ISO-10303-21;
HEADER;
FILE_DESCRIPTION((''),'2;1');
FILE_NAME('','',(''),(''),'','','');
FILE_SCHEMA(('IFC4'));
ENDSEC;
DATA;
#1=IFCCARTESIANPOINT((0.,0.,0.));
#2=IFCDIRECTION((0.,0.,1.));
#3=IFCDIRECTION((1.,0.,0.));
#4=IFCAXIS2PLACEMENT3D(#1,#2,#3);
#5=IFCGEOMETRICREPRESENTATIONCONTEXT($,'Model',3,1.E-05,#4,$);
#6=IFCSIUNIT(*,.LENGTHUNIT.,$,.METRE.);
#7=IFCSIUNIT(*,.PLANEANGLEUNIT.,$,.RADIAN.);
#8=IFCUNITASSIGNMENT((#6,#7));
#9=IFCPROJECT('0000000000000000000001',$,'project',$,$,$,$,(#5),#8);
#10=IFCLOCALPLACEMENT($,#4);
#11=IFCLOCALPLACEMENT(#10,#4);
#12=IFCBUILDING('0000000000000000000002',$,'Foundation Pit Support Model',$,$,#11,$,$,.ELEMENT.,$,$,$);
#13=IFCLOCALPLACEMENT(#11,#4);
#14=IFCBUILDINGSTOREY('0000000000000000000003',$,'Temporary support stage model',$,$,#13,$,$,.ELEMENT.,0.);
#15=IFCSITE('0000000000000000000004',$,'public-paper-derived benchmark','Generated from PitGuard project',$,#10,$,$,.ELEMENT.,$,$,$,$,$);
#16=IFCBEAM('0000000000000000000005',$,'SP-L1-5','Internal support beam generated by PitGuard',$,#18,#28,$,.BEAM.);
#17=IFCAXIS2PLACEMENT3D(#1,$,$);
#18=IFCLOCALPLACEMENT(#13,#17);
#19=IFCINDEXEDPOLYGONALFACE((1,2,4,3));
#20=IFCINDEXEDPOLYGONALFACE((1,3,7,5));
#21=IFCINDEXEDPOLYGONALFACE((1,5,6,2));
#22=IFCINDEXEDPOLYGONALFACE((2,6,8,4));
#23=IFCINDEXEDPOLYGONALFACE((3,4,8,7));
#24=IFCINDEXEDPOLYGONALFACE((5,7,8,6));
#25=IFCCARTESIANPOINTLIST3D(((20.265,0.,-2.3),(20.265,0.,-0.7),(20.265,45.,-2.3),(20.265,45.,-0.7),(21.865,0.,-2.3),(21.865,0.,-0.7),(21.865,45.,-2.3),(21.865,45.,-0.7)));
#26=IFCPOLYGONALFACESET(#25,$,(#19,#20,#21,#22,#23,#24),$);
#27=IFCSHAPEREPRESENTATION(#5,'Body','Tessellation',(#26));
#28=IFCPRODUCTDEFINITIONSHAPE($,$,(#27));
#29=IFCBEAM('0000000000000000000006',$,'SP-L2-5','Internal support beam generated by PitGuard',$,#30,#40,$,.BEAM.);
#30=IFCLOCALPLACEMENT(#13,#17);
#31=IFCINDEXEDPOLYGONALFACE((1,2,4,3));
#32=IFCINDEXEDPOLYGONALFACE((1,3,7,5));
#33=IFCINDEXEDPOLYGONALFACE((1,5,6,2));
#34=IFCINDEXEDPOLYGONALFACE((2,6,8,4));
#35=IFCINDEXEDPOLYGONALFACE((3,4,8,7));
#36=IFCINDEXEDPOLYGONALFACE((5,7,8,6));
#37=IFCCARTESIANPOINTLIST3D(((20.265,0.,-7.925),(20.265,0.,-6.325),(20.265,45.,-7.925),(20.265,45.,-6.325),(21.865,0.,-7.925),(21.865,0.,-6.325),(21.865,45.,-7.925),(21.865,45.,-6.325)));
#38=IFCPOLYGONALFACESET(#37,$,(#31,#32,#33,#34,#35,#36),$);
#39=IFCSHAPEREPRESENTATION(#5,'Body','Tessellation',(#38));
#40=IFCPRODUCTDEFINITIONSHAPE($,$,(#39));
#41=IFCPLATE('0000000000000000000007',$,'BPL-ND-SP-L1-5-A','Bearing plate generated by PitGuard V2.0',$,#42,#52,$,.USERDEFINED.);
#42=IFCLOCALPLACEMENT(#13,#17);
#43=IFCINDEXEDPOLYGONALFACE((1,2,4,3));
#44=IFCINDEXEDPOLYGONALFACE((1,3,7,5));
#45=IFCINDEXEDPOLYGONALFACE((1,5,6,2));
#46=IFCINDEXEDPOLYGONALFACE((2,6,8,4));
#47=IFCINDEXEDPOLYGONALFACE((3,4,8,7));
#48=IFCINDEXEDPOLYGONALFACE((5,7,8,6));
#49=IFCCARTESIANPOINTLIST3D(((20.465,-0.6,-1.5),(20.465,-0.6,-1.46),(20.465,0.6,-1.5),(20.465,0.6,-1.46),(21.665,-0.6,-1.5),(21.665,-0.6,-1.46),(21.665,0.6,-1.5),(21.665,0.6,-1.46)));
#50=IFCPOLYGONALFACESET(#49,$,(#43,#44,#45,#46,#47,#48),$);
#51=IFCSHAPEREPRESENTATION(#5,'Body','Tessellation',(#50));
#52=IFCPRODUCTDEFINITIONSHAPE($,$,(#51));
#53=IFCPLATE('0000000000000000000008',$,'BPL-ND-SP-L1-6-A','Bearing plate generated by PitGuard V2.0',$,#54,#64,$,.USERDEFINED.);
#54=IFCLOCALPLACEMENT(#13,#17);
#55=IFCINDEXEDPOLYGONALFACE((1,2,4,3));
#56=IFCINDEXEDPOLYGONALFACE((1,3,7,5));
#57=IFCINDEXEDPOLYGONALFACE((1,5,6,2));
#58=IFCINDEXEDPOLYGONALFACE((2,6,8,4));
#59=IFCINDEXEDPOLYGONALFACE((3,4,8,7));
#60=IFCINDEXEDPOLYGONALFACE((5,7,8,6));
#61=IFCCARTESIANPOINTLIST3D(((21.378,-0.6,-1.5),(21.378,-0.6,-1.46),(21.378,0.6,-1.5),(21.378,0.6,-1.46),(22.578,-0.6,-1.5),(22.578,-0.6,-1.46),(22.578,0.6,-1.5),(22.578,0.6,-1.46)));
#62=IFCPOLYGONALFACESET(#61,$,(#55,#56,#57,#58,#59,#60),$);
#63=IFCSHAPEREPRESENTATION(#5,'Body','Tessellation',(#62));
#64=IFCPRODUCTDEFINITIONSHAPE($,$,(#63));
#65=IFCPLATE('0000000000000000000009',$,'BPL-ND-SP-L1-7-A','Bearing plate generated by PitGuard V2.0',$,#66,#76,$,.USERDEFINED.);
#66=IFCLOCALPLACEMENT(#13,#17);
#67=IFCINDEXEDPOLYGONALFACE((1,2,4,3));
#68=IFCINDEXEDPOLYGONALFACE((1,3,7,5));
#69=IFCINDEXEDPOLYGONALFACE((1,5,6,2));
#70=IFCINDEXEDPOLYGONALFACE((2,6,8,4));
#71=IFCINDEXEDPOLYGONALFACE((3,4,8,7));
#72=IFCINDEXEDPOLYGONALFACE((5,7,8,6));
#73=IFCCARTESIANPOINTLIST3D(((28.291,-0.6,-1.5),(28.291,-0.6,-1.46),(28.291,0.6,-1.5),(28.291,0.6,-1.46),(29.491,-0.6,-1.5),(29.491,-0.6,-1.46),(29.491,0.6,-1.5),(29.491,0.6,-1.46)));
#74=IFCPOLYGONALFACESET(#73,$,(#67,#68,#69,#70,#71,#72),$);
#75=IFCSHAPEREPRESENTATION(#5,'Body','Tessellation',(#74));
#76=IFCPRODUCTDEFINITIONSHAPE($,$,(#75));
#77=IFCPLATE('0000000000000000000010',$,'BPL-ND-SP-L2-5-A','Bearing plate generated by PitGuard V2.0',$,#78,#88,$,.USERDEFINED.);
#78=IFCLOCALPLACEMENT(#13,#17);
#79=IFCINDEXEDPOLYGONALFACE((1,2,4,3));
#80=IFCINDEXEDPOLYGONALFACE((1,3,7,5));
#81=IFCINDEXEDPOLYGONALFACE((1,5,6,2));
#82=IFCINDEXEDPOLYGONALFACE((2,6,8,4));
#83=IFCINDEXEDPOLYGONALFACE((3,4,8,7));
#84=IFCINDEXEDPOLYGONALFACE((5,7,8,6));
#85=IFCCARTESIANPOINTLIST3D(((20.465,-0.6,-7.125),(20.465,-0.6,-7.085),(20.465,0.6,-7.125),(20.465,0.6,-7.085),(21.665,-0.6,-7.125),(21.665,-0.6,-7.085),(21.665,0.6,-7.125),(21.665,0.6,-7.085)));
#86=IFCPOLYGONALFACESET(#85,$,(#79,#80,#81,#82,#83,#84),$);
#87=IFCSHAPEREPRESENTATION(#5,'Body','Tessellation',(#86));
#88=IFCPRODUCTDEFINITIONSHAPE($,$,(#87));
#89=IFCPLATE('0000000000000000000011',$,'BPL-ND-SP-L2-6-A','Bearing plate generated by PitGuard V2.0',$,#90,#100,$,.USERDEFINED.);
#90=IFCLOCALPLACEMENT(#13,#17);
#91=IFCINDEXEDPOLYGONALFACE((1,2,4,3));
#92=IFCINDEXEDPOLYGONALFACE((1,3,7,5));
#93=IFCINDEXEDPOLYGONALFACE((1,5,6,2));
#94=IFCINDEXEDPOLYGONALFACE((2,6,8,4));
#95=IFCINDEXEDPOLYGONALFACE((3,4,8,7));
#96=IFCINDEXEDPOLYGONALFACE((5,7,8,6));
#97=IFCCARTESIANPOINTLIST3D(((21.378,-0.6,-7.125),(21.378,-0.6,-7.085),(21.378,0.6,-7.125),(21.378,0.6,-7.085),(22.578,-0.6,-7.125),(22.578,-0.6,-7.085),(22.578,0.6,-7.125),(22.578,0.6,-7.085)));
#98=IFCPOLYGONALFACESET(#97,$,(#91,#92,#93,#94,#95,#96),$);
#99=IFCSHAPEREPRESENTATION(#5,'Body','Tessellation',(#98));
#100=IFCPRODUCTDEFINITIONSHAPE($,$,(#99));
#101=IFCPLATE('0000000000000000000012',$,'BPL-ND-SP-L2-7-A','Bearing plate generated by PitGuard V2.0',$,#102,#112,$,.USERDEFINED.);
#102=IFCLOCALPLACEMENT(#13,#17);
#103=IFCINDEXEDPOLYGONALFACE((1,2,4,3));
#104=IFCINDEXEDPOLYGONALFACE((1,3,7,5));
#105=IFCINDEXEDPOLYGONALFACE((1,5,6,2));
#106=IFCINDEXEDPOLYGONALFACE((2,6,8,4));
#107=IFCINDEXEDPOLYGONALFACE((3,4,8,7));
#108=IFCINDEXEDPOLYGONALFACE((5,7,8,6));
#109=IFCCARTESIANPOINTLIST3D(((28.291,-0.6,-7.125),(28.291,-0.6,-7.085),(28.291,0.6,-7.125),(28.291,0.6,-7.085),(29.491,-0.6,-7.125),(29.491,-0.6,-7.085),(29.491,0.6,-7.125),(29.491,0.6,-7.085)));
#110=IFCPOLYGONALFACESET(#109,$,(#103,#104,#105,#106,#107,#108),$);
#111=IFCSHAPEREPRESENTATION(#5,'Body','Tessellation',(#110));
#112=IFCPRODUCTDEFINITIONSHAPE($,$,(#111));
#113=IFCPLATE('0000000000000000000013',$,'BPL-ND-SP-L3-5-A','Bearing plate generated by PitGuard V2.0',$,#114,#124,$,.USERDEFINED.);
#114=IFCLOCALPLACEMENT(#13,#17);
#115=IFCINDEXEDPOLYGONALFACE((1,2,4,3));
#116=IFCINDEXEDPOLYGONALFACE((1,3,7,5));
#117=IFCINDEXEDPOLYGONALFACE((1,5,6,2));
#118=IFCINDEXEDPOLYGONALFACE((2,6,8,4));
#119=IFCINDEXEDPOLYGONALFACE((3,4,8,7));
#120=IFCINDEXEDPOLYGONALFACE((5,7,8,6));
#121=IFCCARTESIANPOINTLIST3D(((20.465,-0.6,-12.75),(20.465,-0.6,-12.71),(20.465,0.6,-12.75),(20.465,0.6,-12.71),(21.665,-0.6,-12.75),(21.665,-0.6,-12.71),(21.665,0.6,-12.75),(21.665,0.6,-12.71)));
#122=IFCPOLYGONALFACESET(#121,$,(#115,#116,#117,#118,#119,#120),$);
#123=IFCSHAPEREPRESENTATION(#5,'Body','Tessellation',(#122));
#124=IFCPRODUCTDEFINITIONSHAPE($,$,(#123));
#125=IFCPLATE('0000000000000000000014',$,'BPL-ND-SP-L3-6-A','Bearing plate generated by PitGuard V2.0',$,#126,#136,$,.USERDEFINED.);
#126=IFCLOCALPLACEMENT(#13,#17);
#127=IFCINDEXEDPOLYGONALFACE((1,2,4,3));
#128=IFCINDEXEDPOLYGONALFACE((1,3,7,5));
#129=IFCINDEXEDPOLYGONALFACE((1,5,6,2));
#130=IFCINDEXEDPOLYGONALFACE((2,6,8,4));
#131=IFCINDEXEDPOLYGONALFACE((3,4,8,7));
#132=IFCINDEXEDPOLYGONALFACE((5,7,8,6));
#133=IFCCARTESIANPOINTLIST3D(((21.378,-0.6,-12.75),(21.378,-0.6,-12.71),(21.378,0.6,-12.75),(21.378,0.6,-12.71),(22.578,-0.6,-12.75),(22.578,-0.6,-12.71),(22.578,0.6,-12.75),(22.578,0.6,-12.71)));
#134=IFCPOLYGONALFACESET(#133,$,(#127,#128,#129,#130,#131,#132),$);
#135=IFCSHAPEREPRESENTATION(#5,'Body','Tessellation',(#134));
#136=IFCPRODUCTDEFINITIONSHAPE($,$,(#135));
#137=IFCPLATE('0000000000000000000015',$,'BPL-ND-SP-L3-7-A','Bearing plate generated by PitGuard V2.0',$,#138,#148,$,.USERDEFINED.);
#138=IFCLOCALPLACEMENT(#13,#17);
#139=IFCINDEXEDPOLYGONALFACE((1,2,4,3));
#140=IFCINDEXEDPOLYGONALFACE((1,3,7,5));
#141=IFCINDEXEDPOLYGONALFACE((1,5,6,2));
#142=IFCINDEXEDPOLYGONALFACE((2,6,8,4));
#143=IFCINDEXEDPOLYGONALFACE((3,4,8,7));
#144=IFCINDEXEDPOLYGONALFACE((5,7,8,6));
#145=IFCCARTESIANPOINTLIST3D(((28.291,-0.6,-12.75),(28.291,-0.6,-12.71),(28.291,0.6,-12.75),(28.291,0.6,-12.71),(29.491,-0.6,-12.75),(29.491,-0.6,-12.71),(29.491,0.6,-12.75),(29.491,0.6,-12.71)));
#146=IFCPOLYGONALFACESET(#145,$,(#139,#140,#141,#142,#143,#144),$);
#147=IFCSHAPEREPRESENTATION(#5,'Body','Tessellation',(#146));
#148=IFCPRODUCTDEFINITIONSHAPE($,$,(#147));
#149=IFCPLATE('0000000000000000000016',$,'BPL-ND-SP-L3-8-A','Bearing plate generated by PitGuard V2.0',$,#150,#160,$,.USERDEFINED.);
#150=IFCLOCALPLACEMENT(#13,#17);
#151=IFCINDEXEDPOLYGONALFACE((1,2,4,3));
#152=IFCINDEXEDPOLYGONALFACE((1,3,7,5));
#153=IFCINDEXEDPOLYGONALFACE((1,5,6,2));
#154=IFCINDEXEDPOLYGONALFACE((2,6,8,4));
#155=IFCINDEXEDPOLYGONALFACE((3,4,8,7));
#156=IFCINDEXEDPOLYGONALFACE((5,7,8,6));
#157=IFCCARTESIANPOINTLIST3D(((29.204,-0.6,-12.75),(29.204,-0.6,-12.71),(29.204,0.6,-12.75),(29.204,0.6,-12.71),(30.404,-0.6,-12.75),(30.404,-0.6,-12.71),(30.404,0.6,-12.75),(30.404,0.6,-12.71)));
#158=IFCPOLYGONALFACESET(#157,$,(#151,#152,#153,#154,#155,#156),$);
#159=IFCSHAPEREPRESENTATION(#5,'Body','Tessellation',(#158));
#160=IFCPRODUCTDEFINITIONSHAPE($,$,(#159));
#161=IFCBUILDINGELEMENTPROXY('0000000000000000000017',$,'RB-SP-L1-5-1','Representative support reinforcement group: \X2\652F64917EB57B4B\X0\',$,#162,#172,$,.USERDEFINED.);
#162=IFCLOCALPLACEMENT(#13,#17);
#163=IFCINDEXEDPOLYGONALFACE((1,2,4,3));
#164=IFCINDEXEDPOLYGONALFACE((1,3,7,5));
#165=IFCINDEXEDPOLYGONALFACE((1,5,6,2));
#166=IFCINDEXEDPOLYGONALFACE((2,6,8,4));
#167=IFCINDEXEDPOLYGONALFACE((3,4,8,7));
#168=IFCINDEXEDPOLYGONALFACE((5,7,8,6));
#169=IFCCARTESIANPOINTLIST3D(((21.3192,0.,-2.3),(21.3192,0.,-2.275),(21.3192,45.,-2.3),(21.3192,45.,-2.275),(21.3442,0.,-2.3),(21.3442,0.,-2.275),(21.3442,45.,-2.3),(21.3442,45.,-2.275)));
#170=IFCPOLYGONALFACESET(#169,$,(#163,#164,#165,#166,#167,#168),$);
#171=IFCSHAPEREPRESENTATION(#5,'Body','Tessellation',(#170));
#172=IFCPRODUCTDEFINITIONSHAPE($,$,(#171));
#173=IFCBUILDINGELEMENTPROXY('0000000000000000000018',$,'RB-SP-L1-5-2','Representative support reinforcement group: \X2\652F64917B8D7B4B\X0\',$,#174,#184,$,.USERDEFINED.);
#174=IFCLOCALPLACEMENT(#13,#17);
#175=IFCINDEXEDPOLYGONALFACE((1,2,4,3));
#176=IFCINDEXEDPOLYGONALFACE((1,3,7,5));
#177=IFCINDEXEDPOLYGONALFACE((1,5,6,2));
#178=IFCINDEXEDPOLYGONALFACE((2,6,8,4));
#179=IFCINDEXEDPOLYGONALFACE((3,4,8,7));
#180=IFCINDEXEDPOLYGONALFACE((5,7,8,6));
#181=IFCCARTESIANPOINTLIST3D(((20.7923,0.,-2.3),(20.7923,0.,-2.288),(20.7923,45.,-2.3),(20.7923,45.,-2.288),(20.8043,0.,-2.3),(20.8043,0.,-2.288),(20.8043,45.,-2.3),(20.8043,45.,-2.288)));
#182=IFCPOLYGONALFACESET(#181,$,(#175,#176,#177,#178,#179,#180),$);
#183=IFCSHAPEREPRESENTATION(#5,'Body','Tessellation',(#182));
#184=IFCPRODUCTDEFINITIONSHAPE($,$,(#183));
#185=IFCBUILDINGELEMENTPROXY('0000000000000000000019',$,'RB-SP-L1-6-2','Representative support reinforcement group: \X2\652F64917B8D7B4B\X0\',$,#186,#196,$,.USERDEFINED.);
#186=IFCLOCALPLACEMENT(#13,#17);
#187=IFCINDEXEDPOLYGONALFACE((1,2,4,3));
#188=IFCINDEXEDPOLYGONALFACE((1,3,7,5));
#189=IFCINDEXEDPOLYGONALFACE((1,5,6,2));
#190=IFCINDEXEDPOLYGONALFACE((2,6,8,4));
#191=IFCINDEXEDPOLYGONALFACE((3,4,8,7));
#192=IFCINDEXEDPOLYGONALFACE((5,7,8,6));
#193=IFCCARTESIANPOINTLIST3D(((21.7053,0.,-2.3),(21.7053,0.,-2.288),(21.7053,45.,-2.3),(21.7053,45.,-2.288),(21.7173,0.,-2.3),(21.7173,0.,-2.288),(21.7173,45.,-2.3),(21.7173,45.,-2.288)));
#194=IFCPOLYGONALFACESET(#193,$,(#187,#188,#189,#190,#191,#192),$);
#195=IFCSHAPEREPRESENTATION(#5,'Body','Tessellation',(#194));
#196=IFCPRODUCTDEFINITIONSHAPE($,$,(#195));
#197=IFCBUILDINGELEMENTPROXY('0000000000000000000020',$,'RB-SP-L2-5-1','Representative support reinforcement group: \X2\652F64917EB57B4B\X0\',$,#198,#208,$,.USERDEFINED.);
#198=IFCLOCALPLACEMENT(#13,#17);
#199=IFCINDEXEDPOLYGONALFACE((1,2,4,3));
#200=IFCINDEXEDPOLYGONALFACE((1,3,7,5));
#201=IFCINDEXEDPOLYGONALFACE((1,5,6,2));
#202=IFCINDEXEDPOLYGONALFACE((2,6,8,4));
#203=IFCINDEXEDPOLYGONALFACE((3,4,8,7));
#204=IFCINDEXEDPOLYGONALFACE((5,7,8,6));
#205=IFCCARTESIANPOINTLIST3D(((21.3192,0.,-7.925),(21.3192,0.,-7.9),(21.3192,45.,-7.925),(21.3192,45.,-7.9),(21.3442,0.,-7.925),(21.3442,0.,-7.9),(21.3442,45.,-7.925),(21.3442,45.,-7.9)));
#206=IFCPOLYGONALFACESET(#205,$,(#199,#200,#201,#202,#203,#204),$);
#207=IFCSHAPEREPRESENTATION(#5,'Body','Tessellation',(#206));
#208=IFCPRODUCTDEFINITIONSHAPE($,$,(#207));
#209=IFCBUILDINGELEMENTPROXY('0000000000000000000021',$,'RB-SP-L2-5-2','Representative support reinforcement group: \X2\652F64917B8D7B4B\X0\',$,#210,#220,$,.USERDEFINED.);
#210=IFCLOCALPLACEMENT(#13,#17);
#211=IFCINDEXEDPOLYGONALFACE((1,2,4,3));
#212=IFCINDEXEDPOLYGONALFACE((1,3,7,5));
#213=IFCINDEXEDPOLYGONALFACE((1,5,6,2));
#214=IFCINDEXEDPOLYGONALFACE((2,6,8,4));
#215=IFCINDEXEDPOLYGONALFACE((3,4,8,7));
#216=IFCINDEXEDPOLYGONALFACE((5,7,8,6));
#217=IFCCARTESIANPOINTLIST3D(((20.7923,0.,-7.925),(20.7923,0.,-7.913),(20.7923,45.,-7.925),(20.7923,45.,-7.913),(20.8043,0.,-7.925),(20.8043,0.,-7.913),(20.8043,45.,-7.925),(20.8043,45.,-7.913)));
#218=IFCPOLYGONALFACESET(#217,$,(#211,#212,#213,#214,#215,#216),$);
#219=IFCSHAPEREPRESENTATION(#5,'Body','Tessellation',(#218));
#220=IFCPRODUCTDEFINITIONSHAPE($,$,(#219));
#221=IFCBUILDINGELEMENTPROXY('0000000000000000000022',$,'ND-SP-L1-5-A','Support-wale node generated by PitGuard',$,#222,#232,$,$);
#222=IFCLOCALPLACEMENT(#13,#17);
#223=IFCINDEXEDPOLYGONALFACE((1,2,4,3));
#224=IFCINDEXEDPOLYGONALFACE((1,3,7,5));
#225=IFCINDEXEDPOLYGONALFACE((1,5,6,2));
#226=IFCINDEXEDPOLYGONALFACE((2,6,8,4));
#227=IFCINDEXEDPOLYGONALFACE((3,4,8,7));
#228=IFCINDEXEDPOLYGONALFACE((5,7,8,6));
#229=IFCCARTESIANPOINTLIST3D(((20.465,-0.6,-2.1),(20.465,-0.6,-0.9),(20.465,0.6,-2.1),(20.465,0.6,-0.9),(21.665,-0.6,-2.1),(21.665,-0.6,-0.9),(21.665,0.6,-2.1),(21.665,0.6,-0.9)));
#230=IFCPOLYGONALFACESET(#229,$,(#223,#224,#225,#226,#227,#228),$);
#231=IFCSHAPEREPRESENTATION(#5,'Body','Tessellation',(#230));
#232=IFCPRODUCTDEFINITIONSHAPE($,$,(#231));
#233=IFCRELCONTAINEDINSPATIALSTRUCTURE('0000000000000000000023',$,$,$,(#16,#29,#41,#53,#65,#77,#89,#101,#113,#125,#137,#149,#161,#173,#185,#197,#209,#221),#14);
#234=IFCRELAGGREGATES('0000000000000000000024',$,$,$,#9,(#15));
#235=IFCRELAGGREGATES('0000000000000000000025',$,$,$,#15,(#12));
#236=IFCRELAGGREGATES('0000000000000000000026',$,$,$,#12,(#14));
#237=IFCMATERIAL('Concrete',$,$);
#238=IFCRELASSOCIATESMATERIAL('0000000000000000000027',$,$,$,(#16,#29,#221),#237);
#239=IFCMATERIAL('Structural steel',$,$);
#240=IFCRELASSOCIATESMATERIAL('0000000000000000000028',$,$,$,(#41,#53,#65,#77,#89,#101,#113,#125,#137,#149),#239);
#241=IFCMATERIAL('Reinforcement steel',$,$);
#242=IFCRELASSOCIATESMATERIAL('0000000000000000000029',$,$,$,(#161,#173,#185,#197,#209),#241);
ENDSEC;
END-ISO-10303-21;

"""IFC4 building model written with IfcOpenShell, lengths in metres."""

from ifc_helpers import new_model, si_unit, frame, origin_with_axes, origin_2d, place, context, project, spatial, rectangle, extrude, material, element, save


model = new_model("IFC4")

# Units and contexts
model_context = context("Model", 3, precision=1e-05, world=origin_with_axes())
ifc_project = project(units=[si_unit("LENGTHUNIT", "METRE"), si_unit("PLANEANGLEUNIT", "RADIAN")], contexts=[model_context])

# Site, building, storey
site_placement = place(None, origin_with_axes())
site = spatial("IfcSite", under=ifc_project, at=site_placement, Name="public-paper-derived benchmark", Description="Generated from PitGuard project", CompositionType="ELEMENT")
building_placement = place(site_placement, origin_with_axes())
building = spatial("IfcBuilding", under=site, at=building_placement, Name="Foundation Pit Support Model", CompositionType="ELEMENT")
storey_placement = place(building_placement, origin_with_axes())
storey = spatial("IfcBuildingStorey", under=building, at=storey_placement, Name="Temporary support stage model", CompositionType="ELEMENT", Elevation=0.0)

# Beams
ifc_material_1 = material(Name="Concrete")
for number, where, z_axis, x_axis, name in (
    (1, (21.065, 22.5, -2.3), (0.0, 0.0, 1.0), (0.0, 1.0, 0.0), "SP-L1-5"),
    (2, (21.065, 22.5, -7.925), (0.0, 0.0, 1.0), (0.0, 1.0, 0.0), "SP-L2-5"),
):
    element("IfcBeam", number, at=place(storey_placement, frame(where, z_axis=z_axis, x_axis=x_axis)), inside=storey, material=ifc_material_1, Name=name, Description="Internal support beam generated by PitGuard", PredefinedType="BEAM", context=model_context, shape_type="SweptSolid", body=[
        extrude(rectangle(XDim=45.0, YDim=1.6, at=origin_2d()), origin_with_axes(), (0.0, 0.0, 1.0), 1.6),
    ])

# Plates
ifc_material_2 = material(Name="Structural steel")
for number, where, z_axis, x_axis, name in (
    (3, (21.065, 0.0, -1.5), (0.0, 0.0, 1.0), (1.0, 0.0, 0.0), "BPL-ND-SP-L1-5-A"),
    (4, (21.978, 0.0, -1.5), (0.0, 0.0, 1.0), (1.0, 0.0, 0.0), "BPL-ND-SP-L1-6-A"),
    (5, (28.891, 0.0, -1.5), (0.0, 0.0, 1.0), (1.0, 0.0, 0.0), "BPL-ND-SP-L1-7-A"),
    (6, (21.065, 0.0, -7.125), (0.0, 0.0, 1.0), (1.0, 0.0, 0.0), "BPL-ND-SP-L2-5-A"),
    (7, (21.978, 0.0, -7.125), (0.0, 0.0, 1.0), (1.0, 0.0, 0.0), "BPL-ND-SP-L2-6-A"),
    (8, (28.891, 0.0, -7.125), (0.0, 0.0, 1.0), (1.0, 0.0, 0.0), "BPL-ND-SP-L2-7-A"),
    (9, (21.065, 0.0, -12.75), (0.0, 0.0, 1.0), (1.0, 0.0, 0.0), "BPL-ND-SP-L3-5-A"),
    (10, (21.978, 0.0, -12.75), (0.0, 0.0, 1.0), (1.0, 0.0, 0.0), "BPL-ND-SP-L3-6-A"),
    (11, (28.891, 0.0, -12.75), (0.0, 0.0, 1.0), (1.0, 0.0, 0.0), "BPL-ND-SP-L3-7-A"),
    (12, (29.804, 0.0, -12.75), (0.0, 0.0, 1.0), (1.0, 0.0, 0.0), "BPL-ND-SP-L3-8-A"),
):
    element("IfcPlate", number, at=place(storey_placement, frame(where, z_axis=z_axis, x_axis=x_axis)), inside=storey, material=ifc_material_2, Name=name, Description="Bearing plate generated by PitGuard V2.0", PredefinedType="USERDEFINED", context=model_context, shape_type="SweptSolid", body=[
        extrude(rectangle(XDim=1.2, YDim=1.2, at=origin_2d()), origin_with_axes(), (0.0, 0.0, 1.0), 0.04),
    ])

# Building element proxies
ifc_material_3 = material(Name="Reinforcement steel")
proxy_1_placement = place(storey_placement, frame((21.3317, 22.5, -2.3), z_axis=(0.0, 0.0, 1.0), x_axis=(0.0, 1.0, 0.0)))
element("IfcBuildingElementProxy", 13, at=proxy_1_placement, inside=storey, material=ifc_material_3, Name="RB-SP-L1-5-1", Description="Representative support reinforcement group: 支撑纵筋", PredefinedType="USERDEFINED", context=model_context, shape_type="SweptSolid", body=[
    extrude(rectangle(XDim=45.0, YDim=0.025, at=origin_2d()), origin_with_axes(), (0.0, 0.0, 1.0), 0.025),
])
for number, where, z_axis, x_axis, name in (
    (14, (20.7983, 22.5, -2.3), (0.0, 0.0, 1.0), (0.0, 1.0, 0.0), "RB-SP-L1-5-2"),
    (15, (21.7113, 22.5, -2.3), (0.0, 0.0, 1.0), (0.0, 1.0, 0.0), "RB-SP-L1-6-2"),
):
    element("IfcBuildingElementProxy", number, at=place(storey_placement, frame(where, z_axis=z_axis, x_axis=x_axis)), inside=storey, material=ifc_material_3, Name=name, Description="Representative support reinforcement group: 支撑箍筋", PredefinedType="USERDEFINED", context=model_context, shape_type="SweptSolid", body=[
        extrude(rectangle(XDim=45.0, YDim=0.012, at=origin_2d()), origin_with_axes(), (0.0, 0.0, 1.0), 0.012),
    ])
proxy_2_placement = place(storey_placement, frame((21.3317, 22.5, -7.925), z_axis=(0.0, 0.0, 1.0), x_axis=(0.0, 1.0, 0.0)))
element("IfcBuildingElementProxy", 16, at=proxy_2_placement, inside=storey, material=ifc_material_3, Name="RB-SP-L2-5-1", Description="Representative support reinforcement group: 支撑纵筋", PredefinedType="USERDEFINED", context=model_context, shape_type="SweptSolid", body=[
    extrude(rectangle(XDim=45.0, YDim=0.025, at=origin_2d()), origin_with_axes(), (0.0, 0.0, 1.0), 0.025),
])
proxy_3_placement = place(storey_placement, frame((20.7983, 22.5, -7.925), z_axis=(0.0, 0.0, 1.0), x_axis=(0.0, 1.0, 0.0)))
element("IfcBuildingElementProxy", 17, at=proxy_3_placement, inside=storey, material=ifc_material_3, Name="RB-SP-L2-5-2", Description="Representative support reinforcement group: 支撑箍筋", PredefinedType="USERDEFINED", context=model_context, shape_type="SweptSolid", body=[
    extrude(rectangle(XDim=45.0, YDim=0.012, at=origin_2d()), origin_with_axes(), (0.0, 0.0, 1.0), 0.012),
])
proxy_4_placement = place(storey_placement, frame((21.065, 0.0, -2.1), z_axis=(0.0, 0.0, 1.0), x_axis=(1.0, 0.0, 0.0)))
element("IfcBuildingElementProxy", 18, at=proxy_4_placement, inside=storey, material=ifc_material_1, Name="ND-SP-L1-5-A", Description="Support-wale node generated by PitGuard", context=model_context, shape_type="SweptSolid", body=[
    extrude(rectangle(XDim=1.2, YDim=1.2, at=origin_2d()), origin_with_axes(), (0.0, 0.0, 1.0), 1.2),
])

save(model, "model.ifc")
